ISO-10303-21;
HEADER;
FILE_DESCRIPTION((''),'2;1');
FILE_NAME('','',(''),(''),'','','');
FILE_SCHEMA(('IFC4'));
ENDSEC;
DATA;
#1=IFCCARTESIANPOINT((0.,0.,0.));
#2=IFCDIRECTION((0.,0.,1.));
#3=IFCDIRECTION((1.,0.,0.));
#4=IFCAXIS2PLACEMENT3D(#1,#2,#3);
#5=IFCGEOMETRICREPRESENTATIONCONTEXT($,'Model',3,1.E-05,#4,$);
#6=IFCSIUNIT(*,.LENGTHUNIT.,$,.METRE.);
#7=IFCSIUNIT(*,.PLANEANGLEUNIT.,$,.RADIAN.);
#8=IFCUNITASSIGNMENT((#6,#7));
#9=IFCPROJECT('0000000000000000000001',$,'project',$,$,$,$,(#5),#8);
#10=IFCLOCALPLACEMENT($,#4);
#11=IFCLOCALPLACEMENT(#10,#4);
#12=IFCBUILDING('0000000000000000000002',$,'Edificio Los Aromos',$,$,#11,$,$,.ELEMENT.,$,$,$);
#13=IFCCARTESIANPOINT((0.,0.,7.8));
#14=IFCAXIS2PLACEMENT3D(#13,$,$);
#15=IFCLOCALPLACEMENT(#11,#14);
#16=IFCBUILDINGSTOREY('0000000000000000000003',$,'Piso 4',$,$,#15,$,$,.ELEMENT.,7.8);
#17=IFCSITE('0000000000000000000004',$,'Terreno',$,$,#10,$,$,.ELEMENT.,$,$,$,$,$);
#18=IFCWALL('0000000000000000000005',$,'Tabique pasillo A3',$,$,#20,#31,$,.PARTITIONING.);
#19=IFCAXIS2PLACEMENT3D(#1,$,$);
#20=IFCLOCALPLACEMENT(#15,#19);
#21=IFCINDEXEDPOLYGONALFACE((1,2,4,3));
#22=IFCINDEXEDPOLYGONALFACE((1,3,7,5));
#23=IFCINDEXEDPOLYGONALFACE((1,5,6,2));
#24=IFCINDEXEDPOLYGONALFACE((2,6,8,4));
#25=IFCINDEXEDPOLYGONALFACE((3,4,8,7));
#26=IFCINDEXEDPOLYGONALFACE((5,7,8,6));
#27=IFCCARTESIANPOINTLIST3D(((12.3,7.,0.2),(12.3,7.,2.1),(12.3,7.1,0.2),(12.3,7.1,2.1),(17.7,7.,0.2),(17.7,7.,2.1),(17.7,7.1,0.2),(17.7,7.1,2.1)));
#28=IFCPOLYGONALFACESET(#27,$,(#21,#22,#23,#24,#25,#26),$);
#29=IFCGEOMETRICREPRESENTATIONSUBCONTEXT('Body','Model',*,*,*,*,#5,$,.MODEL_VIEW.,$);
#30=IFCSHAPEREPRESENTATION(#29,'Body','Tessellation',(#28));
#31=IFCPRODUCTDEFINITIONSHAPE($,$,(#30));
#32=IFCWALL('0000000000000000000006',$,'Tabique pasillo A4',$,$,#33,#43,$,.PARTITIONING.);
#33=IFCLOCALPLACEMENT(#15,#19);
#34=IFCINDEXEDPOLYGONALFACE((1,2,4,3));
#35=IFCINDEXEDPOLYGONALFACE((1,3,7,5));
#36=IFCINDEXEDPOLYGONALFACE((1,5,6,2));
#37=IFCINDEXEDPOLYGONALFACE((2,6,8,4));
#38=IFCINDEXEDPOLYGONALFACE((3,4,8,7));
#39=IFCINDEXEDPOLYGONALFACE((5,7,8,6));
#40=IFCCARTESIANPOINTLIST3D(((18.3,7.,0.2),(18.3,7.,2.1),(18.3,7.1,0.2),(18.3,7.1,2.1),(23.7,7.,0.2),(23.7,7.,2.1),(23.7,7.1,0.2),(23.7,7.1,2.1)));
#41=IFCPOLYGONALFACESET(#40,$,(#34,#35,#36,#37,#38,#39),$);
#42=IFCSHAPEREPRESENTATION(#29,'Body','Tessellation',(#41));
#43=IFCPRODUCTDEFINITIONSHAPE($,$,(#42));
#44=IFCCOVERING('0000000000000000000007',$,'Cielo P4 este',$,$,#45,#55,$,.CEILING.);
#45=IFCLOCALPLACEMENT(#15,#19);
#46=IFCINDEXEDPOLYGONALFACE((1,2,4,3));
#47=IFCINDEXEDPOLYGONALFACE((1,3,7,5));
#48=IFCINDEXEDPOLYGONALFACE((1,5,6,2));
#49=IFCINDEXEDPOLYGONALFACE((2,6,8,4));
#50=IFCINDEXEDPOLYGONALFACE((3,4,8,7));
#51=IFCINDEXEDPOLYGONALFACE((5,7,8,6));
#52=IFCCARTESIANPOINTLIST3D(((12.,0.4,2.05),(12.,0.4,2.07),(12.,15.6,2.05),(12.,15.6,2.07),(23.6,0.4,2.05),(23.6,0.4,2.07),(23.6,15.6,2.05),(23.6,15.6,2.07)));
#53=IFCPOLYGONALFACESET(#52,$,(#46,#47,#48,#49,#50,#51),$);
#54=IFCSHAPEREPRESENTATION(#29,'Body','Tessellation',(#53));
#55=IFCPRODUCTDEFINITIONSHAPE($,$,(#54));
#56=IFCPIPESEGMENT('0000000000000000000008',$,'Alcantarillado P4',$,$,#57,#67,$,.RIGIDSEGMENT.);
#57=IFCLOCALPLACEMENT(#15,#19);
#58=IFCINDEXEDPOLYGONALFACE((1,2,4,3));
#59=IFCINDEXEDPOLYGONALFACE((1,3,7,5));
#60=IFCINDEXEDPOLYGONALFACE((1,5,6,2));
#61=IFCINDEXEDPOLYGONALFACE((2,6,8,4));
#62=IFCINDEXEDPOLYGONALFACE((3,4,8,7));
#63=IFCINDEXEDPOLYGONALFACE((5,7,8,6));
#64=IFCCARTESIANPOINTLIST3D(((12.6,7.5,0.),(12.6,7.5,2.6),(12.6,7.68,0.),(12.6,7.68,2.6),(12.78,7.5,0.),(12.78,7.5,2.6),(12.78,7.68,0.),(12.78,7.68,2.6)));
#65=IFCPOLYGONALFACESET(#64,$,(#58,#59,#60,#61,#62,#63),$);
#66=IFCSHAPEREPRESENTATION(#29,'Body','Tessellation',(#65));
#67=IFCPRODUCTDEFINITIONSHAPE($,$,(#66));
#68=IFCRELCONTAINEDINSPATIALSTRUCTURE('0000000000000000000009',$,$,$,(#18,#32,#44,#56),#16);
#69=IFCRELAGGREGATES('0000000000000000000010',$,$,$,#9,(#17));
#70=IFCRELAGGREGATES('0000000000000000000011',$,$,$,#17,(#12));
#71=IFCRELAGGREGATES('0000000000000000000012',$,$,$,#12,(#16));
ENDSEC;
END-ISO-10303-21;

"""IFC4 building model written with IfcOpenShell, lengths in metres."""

from ifc_helpers import new_model, si_unit, frame, frame_2d, origin_with_axes, place, context, subcontext, project, spatial, rectangle, extrude, element, save


model = new_model("IFC4")

# Units and contexts
model_context = context("Model", 3, precision=1e-05, world=origin_with_axes())
body_context = subcontext(model_context, "Body", "Model", "MODEL_VIEW")
ifc_project = project(units=[si_unit("LENGTHUNIT", "METRE"), si_unit("PLANEANGLEUNIT", "RADIAN")], contexts=[model_context])

# Site, building, storey
site_placement = place(None, origin_with_axes())
site = spatial("IfcSite", under=ifc_project, at=site_placement, Name="Terreno", CompositionType="ELEMENT")
building_placement = place(site_placement, origin_with_axes())
building = spatial("IfcBuilding", under=site, at=building_placement, Name="Edificio Los Aromos", CompositionType="ELEMENT")
storey_placement = place(building_placement, frame((0.0, 0.0, 7.8)))
storey = spatial("IfcBuildingStorey", under=building, at=storey_placement, Name="Piso 4", CompositionType="ELEMENT", Elevation=7.8)

# Walls
for number, where, name in (
    (1, (12.3, 7.0, 0.2), "Tabique pasillo A3"),
    (2, (18.3, 7.0, 0.2), "Tabique pasillo A4"),
):
    element("IfcWall", number, at=place(storey_placement, frame(where)), inside=storey, Name=name, PredefinedType="PARTITIONING", context=body_context, shape_type="SweptSolid", body=[
        extrude(rectangle(XDim=5.4, YDim=0.1, at=frame_2d((2.7, 0.05))), origin_with_axes(), (0.0, 0.0, 1.0), 1.9),
    ])

# Covering
covering_placement = place(storey_placement, frame((12.0, 0.4, 2.05)))
element("IfcCovering", 3, at=covering_placement, inside=storey, Name="Cielo P4 este", PredefinedType="CEILING", context=body_context, shape_type="SweptSolid", body=[
    extrude(rectangle(XDim=11.6, YDim=15.2, at=frame_2d((5.8, 7.6))), origin_with_axes(), (0.0, 0.0, 1.0), 0.02),
])

# Pipe segment
pipe_segment_placement = place(storey_placement, frame((12.6, 7.5, 0.0)))
element("IfcPipeSegment", 4, at=pipe_segment_placement, inside=storey, Name="Alcantarillado P4", PredefinedType="RIGIDSEGMENT", context=body_context, shape_type="SweptSolid", body=[
    extrude(rectangle(XDim=0.18, YDim=0.18, at=frame_2d((0.09, 0.09))), origin_with_axes(), (0.0, 0.0, 1.0), 2.6),
])

save(model, "model.ifc")
